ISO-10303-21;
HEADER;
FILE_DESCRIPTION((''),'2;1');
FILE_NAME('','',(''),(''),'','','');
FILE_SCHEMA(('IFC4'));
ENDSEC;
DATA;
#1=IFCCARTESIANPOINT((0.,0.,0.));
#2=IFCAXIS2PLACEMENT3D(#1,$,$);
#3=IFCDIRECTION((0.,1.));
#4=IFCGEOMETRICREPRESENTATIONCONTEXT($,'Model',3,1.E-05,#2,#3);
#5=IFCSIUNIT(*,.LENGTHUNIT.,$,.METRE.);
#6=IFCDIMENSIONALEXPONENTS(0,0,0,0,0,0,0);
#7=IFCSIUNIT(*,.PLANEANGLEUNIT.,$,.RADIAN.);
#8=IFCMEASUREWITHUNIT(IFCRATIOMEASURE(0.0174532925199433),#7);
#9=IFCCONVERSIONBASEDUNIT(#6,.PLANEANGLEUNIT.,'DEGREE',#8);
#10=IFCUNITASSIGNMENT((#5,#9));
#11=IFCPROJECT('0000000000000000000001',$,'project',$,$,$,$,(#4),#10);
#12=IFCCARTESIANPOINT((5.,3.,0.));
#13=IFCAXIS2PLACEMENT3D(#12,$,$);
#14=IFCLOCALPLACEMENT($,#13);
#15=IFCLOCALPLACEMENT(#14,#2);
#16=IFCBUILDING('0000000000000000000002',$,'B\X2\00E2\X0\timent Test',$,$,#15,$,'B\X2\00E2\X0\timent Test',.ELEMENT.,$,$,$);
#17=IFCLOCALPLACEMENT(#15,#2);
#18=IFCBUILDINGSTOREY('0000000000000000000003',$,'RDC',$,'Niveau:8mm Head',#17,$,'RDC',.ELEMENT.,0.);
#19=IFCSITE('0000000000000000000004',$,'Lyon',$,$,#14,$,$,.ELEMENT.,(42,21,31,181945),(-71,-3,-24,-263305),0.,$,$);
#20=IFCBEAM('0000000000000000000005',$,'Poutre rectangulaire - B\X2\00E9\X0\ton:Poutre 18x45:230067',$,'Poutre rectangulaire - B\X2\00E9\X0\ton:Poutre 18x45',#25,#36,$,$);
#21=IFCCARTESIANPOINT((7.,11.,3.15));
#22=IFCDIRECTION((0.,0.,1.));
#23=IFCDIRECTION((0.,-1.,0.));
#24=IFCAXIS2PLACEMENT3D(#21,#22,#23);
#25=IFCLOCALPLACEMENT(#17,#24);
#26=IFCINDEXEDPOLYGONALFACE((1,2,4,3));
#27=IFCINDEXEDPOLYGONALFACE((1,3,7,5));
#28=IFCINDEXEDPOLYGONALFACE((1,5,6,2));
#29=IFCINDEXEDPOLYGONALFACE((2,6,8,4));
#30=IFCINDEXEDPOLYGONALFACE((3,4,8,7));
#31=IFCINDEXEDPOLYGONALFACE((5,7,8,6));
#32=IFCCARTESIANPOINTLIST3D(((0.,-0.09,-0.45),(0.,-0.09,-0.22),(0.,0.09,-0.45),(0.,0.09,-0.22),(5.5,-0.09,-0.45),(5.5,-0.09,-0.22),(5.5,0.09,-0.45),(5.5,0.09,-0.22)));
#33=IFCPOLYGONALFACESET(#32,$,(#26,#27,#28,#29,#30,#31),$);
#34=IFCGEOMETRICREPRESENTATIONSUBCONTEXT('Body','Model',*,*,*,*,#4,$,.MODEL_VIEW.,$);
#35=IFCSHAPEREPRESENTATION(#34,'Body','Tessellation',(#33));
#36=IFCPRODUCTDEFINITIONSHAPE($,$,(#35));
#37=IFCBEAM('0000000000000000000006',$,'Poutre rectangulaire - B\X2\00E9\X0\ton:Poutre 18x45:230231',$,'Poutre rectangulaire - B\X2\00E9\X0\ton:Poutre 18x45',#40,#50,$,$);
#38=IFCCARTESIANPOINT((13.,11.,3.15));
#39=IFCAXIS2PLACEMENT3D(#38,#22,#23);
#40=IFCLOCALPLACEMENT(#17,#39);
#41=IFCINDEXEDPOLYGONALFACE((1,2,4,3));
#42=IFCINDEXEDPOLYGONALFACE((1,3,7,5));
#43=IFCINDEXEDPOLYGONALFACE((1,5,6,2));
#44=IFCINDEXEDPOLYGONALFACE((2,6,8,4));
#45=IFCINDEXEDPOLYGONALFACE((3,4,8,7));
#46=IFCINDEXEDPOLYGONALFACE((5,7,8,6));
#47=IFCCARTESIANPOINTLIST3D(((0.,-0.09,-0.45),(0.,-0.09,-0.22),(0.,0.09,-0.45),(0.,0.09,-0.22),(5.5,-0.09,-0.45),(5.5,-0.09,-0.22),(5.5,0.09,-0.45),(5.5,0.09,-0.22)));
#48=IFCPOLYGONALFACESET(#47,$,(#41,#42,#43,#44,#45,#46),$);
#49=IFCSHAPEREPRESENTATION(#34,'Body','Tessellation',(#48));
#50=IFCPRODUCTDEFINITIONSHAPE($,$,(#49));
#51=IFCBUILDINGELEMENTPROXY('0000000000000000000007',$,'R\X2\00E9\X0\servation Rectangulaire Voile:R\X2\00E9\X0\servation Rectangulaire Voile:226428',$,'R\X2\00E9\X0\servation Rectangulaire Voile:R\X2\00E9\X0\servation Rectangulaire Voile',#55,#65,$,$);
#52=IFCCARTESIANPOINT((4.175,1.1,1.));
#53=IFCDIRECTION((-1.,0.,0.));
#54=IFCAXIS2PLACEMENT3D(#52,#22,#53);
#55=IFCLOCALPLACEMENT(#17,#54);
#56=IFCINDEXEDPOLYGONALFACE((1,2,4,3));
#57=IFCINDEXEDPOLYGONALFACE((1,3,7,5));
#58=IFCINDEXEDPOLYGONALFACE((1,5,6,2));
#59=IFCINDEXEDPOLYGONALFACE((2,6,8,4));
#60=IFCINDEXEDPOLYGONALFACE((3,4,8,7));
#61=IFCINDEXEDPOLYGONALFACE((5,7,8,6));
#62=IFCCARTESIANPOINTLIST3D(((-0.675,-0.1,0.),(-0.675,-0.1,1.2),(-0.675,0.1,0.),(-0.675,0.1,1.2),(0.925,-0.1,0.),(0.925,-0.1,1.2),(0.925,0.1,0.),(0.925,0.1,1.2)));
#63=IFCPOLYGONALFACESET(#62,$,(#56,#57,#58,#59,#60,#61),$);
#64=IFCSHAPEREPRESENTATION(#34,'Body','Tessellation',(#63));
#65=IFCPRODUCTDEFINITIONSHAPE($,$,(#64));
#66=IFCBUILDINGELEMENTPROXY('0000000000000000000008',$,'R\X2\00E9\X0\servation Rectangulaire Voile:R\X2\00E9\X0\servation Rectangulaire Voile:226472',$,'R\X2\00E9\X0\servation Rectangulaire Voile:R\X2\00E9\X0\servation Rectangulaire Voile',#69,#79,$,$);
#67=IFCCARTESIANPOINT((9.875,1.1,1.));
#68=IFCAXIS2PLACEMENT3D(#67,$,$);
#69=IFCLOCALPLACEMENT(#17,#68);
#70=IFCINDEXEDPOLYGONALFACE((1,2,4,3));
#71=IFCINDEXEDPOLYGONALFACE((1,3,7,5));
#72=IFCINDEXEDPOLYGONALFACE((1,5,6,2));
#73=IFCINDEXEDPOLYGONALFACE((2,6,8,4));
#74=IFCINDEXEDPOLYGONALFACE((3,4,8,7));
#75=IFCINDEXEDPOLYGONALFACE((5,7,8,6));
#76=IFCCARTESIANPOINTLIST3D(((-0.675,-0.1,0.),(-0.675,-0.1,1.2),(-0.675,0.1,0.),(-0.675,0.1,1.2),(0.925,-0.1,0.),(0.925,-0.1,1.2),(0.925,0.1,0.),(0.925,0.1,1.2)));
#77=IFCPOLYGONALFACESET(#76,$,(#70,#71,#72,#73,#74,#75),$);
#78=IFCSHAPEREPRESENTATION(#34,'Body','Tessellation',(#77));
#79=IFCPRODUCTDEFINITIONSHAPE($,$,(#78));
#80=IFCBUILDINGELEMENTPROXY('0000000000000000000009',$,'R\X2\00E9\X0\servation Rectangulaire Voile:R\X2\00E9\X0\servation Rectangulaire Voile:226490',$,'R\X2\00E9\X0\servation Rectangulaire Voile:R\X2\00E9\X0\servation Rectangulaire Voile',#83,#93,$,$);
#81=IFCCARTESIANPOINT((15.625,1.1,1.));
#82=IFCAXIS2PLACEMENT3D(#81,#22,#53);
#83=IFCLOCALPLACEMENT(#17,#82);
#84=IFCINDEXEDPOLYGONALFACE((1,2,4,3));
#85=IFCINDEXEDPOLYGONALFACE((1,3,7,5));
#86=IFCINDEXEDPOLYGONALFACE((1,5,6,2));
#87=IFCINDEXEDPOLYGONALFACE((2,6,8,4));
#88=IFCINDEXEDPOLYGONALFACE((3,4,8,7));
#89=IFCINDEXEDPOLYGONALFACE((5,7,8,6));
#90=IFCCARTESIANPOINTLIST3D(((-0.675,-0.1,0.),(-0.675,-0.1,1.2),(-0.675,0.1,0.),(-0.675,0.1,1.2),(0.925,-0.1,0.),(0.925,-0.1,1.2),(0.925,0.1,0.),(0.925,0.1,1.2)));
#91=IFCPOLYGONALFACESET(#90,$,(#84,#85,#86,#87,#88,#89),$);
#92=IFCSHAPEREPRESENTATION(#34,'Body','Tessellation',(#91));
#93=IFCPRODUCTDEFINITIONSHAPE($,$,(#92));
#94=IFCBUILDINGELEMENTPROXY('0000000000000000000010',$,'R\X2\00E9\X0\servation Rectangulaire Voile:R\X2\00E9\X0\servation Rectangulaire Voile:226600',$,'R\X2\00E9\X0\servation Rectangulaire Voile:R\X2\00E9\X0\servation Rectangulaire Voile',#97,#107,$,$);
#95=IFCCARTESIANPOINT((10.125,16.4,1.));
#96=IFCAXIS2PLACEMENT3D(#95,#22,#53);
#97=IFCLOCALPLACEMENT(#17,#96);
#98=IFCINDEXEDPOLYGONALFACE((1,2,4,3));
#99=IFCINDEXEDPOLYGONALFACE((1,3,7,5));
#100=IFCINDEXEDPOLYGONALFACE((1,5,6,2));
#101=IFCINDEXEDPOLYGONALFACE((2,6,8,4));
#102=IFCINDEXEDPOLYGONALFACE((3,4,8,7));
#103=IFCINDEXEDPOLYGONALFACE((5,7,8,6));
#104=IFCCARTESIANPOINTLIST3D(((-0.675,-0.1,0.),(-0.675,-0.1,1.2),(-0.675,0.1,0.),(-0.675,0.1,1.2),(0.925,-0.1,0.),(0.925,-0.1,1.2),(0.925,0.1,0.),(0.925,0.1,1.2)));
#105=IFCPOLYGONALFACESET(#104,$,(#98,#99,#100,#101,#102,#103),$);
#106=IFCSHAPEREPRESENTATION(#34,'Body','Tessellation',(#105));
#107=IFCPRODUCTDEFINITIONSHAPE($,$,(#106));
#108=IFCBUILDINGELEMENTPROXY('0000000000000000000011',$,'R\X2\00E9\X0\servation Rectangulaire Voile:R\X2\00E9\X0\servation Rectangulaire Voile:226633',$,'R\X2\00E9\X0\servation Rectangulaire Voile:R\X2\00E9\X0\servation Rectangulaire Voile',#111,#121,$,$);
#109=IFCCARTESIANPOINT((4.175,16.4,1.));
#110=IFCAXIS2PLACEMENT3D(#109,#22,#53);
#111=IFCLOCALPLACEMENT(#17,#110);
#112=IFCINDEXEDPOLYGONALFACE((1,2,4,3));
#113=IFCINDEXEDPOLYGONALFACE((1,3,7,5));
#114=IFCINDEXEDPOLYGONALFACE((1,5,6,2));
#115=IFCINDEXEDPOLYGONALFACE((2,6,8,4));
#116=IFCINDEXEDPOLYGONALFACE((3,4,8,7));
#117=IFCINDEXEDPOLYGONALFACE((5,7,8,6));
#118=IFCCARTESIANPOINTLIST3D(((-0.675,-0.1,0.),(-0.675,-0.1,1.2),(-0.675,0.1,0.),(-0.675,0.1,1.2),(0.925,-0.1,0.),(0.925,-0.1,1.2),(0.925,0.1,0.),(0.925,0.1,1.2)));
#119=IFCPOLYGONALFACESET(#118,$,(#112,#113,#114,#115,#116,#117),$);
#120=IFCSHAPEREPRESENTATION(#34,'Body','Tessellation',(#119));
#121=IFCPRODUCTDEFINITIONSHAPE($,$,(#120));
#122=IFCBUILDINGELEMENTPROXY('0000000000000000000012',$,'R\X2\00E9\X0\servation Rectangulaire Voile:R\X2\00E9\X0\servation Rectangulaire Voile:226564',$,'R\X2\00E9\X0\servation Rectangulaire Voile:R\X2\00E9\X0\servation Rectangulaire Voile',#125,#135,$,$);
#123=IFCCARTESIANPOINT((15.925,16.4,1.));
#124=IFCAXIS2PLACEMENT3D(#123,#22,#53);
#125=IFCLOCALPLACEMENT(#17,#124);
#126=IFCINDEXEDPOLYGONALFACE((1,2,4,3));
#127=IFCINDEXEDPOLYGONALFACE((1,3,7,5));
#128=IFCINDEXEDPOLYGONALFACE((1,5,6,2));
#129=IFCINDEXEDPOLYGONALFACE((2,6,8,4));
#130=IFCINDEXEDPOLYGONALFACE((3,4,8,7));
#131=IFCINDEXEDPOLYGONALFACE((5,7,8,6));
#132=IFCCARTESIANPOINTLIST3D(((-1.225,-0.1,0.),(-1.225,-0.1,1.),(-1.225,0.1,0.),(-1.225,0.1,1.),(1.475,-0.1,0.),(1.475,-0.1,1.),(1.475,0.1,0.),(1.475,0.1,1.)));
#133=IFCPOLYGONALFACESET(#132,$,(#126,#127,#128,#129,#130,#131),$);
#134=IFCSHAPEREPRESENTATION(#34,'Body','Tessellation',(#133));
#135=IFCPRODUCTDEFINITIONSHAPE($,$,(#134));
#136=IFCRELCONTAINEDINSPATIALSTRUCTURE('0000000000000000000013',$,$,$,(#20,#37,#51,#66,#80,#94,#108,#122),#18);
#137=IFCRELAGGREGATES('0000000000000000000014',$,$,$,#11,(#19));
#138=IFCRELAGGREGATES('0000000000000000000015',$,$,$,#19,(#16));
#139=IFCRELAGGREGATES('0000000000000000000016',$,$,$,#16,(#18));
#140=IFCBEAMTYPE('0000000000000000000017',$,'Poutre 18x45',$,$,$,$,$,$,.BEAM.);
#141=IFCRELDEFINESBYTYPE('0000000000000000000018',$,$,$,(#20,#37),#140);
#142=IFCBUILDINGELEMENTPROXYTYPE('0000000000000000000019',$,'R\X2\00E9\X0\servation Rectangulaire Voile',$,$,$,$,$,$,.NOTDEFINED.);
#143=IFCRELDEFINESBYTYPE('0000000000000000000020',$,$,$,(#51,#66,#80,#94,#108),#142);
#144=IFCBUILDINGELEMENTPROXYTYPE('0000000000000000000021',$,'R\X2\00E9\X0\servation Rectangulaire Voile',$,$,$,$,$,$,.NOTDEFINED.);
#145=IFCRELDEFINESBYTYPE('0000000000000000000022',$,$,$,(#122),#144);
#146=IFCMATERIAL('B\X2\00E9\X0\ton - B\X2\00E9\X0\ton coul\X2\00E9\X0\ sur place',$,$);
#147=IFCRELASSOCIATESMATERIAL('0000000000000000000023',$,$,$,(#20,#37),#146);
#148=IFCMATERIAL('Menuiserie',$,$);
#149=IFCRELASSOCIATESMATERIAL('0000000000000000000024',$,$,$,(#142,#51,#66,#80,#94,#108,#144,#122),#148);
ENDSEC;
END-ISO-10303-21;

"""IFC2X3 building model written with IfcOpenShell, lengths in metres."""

from ifc_helpers import new_model, entity, si_unit, converted_unit, direction, frame, frame_2d, origin, origin_2d_with_axis, place, context, subcontext, project, spatial, rectangle, extrude, source, transform, mapped, material, type_object, type_shapes, element, save


model = new_model("IFC2X3")

# Units and contexts
model_context = context("Model", 3, precision=1e-05, world=origin(), true_north=direction((0.0, 1.0)))
body_context = subcontext(model_context, "Body", "Model", "MODEL_VIEW")
ifc_project = project(units=[si_unit("LENGTHUNIT", "METRE"), converted_unit("PLANEANGLEUNIT", "DEGREE", entity("IfcRatioMeasure", 0.0174532925199433), si_unit("PLANEANGLEUNIT", "RADIAN"), dimensions=[0, 0, 0, 0, 0, 0, 0])], contexts=[model_context])

# Site, building, storey
site_placement = place(None, frame((5.0, 3.0, 0.0)))
site = spatial("IfcSite", under=ifc_project, at=site_placement, Name="Lyon", CompositionType="ELEMENT", RefLatitude=(42, 21, 31, 181945), RefLongitude=(-71, -3, -24, -263305), RefElevation=0.0)
building_placement = place(site_placement, origin())
building = spatial("IfcBuilding", under=site, at=building_placement, Name="Bâtiment Test", LongName="Bâtiment Test", CompositionType="ELEMENT")
storey_placement = place(building_placement, origin())
storey = spatial("IfcBuildingStorey", under=building, at=storey_placement, Name="RDC", ObjectType="Niveau:8mm Head", LongName="RDC", CompositionType="ELEMENT", Elevation=0.0)

# Beams
ifc_material_1 = material(Name="Béton - Béton coulé sur place")
beam_type = type_object("IfcBeamType", Name="Poutre 18x45", PredefinedType="BEAM")
beam_1_placement = place(storey_placement, frame((7.0, 11.0, 3.15), z_axis=(0.0, 0.0, 1.0), x_axis=(0.0, -1.0, 0.0)))
element("IfcBeam", 1, at=beam_1_placement, inside=storey, type_object=beam_type, material=ifc_material_1, Name="Poutre rectangulaire - Béton:Poutre 18x45:230067", ObjectType="Poutre rectangulaire - Béton:Poutre 18x45", context=body_context, shape_type="SweptSolid", body=[
    extrude(rectangle(XDim=0.23, YDim=0.18, at=origin_2d_with_axis()), frame((0.0, 0.0, -0.335), z_axis=(1.0, 0.0, 0.0), x_axis=(0.0, 0.0, -1.0)), (0.0, 0.0, 1.0), 5.5),
])
beam_2_placement = place(storey_placement, frame((13.0, 11.0, 3.15), z_axis=(0.0, 0.0, 1.0), x_axis=(0.0, -1.0, 0.0)))
element("IfcBeam", 2, at=beam_2_placement, inside=storey, type_object=beam_type, material=ifc_material_1, Name="Poutre rectangulaire - Béton:Poutre 18x45:230231", ObjectType="Poutre rectangulaire - Béton:Poutre 18x45", context=body_context, shape_type="SweptSolid", body=[
    extrude(rectangle(XDim=0.23, YDim=0.18, at=frame_2d((0.0, 0.0), x_axis=(1.0, 0.0))), frame((0.0, 0.0, -0.335), z_axis=(1.0, 0.0, 0.0), x_axis=(0.0, 0.0, -1.0)), (0.0, 0.0, 1.0), 5.5),
])

# Building element proxies
ifc_material_2 = material(Name="Menuiserie")
building_element_proxy_type_1 = type_object("IfcBuildingElementProxyType", Name="Réservation Rectangulaire Voile", PredefinedType="NOTDEFINED", material=ifc_material_2)
shared_shape_1 = source(origin(), body_context, "Body", "SweptSolid", [
    extrude(rectangle(XDim=0.2, YDim=1.6, at=origin_2d_with_axis()), frame((0.125, 0.0, 0.0), z_axis=(0.0, 0.0, 1.0), x_axis=(0.0, 1.0, 0.0)), (0.0, 0.0, 1.0), 1.2),
])
type_shapes(building_element_proxy_type_1, [shared_shape_1])
proxy_1_placement = place(storey_placement, frame((4.175, 1.1, 1.0), z_axis=(0.0, 0.0, 1.0), x_axis=(-1.0, 0.0, 0.0)))
element("IfcBuildingElementProxy", 3, at=proxy_1_placement, inside=storey, type_object=building_element_proxy_type_1, material=ifc_material_2, Name="Réservation Rectangulaire Voile:Réservation Rectangulaire Voile:226428", ObjectType="Réservation Rectangulaire Voile:Réservation Rectangulaire Voile", context=body_context, shape_type="MappedRepresentation", body=[
    mapped(shared_shape_1, transform((0.0, 0.0, 0.0), scale=1.0)),
])
proxy_2_placement = place(storey_placement, frame((9.875, 1.1, 1.0)))
element("IfcBuildingElementProxy", 4, at=proxy_2_placement, inside=storey, type_object=building_element_proxy_type_1, material=ifc_material_2, Name="Réservation Rectangulaire Voile:Réservation Rectangulaire Voile:226472", ObjectType="Réservation Rectangulaire Voile:Réservation Rectangulaire Voile", context=body_context, shape_type="MappedRepresentation", body=[
    mapped(shared_shape_1, transform((0.0, 0.0, 0.0), scale=1.0)),
])
for number, where, z_axis, x_axis, name in (
    (5, (15.625, 1.1, 1.0), (0.0, 0.0, 1.0), (-1.0, 0.0, 0.0), "Réservation Rectangulaire Voile:Réservation Rectangulaire Voile:226490"),
    (6, (10.125, 16.4, 1.0), (0.0, 0.0, 1.0), (-1.0, 0.0, 0.0), "Réservation Rectangulaire Voile:Réservation Rectangulaire Voile:226600"),
    (7, (4.175, 16.4, 1.0), (0.0, 0.0, 1.0), (-1.0, 0.0, 0.0), "Réservation Rectangulaire Voile:Réservation Rectangulaire Voile:226633"),
):
    element("IfcBuildingElementProxy", number, at=place(storey_placement, frame(where, z_axis=z_axis, x_axis=x_axis)), inside=storey, type_object=building_element_proxy_type_1, material=ifc_material_2, Name=name, ObjectType="Réservation Rectangulaire Voile:Réservation Rectangulaire Voile", context=body_context, shape_type="MappedRepresentation", body=[
        mapped(shared_shape_1, transform((0.0, 0.0, 0.0), scale=1.0)),
    ])
building_element_proxy_type_2 = type_object("IfcBuildingElementProxyType", Name="Réservation Rectangulaire Voile", PredefinedType="NOTDEFINED", material=ifc_material_2)
shared_shape_2 = source(origin(), body_context, "Body", "SweptSolid", [
    extrude(rectangle(XDim=0.2, YDim=2.7, at=origin_2d_with_axis()), frame((0.125, 0.0, 0.0), z_axis=(0.0, 0.0, 1.0), x_axis=(0.0, 1.0, 0.0)), (0.0, 0.0, 1.0), 1.0),
])
type_shapes(building_element_proxy_type_2, [shared_shape_2])
proxy_3_placement = place(storey_placement, frame((15.925, 16.4, 1.0), z_axis=(0.0, 0.0, 1.0), x_axis=(-1.0, 0.0, 0.0)))
element("IfcBuildingElementProxy", 8, at=proxy_3_placement, inside=storey, type_object=building_element_proxy_type_2, material=ifc_material_2, Name="Réservation Rectangulaire Voile:Réservation Rectangulaire Voile:226564", ObjectType="Réservation Rectangulaire Voile:Réservation Rectangulaire Voile", context=body_context, shape_type="MappedRepresentation", body=[
    mapped(shared_shape_2, transform((0.0, 0.0, 0.0), scale=1.0)),
])

save(model, "model.ifc")
